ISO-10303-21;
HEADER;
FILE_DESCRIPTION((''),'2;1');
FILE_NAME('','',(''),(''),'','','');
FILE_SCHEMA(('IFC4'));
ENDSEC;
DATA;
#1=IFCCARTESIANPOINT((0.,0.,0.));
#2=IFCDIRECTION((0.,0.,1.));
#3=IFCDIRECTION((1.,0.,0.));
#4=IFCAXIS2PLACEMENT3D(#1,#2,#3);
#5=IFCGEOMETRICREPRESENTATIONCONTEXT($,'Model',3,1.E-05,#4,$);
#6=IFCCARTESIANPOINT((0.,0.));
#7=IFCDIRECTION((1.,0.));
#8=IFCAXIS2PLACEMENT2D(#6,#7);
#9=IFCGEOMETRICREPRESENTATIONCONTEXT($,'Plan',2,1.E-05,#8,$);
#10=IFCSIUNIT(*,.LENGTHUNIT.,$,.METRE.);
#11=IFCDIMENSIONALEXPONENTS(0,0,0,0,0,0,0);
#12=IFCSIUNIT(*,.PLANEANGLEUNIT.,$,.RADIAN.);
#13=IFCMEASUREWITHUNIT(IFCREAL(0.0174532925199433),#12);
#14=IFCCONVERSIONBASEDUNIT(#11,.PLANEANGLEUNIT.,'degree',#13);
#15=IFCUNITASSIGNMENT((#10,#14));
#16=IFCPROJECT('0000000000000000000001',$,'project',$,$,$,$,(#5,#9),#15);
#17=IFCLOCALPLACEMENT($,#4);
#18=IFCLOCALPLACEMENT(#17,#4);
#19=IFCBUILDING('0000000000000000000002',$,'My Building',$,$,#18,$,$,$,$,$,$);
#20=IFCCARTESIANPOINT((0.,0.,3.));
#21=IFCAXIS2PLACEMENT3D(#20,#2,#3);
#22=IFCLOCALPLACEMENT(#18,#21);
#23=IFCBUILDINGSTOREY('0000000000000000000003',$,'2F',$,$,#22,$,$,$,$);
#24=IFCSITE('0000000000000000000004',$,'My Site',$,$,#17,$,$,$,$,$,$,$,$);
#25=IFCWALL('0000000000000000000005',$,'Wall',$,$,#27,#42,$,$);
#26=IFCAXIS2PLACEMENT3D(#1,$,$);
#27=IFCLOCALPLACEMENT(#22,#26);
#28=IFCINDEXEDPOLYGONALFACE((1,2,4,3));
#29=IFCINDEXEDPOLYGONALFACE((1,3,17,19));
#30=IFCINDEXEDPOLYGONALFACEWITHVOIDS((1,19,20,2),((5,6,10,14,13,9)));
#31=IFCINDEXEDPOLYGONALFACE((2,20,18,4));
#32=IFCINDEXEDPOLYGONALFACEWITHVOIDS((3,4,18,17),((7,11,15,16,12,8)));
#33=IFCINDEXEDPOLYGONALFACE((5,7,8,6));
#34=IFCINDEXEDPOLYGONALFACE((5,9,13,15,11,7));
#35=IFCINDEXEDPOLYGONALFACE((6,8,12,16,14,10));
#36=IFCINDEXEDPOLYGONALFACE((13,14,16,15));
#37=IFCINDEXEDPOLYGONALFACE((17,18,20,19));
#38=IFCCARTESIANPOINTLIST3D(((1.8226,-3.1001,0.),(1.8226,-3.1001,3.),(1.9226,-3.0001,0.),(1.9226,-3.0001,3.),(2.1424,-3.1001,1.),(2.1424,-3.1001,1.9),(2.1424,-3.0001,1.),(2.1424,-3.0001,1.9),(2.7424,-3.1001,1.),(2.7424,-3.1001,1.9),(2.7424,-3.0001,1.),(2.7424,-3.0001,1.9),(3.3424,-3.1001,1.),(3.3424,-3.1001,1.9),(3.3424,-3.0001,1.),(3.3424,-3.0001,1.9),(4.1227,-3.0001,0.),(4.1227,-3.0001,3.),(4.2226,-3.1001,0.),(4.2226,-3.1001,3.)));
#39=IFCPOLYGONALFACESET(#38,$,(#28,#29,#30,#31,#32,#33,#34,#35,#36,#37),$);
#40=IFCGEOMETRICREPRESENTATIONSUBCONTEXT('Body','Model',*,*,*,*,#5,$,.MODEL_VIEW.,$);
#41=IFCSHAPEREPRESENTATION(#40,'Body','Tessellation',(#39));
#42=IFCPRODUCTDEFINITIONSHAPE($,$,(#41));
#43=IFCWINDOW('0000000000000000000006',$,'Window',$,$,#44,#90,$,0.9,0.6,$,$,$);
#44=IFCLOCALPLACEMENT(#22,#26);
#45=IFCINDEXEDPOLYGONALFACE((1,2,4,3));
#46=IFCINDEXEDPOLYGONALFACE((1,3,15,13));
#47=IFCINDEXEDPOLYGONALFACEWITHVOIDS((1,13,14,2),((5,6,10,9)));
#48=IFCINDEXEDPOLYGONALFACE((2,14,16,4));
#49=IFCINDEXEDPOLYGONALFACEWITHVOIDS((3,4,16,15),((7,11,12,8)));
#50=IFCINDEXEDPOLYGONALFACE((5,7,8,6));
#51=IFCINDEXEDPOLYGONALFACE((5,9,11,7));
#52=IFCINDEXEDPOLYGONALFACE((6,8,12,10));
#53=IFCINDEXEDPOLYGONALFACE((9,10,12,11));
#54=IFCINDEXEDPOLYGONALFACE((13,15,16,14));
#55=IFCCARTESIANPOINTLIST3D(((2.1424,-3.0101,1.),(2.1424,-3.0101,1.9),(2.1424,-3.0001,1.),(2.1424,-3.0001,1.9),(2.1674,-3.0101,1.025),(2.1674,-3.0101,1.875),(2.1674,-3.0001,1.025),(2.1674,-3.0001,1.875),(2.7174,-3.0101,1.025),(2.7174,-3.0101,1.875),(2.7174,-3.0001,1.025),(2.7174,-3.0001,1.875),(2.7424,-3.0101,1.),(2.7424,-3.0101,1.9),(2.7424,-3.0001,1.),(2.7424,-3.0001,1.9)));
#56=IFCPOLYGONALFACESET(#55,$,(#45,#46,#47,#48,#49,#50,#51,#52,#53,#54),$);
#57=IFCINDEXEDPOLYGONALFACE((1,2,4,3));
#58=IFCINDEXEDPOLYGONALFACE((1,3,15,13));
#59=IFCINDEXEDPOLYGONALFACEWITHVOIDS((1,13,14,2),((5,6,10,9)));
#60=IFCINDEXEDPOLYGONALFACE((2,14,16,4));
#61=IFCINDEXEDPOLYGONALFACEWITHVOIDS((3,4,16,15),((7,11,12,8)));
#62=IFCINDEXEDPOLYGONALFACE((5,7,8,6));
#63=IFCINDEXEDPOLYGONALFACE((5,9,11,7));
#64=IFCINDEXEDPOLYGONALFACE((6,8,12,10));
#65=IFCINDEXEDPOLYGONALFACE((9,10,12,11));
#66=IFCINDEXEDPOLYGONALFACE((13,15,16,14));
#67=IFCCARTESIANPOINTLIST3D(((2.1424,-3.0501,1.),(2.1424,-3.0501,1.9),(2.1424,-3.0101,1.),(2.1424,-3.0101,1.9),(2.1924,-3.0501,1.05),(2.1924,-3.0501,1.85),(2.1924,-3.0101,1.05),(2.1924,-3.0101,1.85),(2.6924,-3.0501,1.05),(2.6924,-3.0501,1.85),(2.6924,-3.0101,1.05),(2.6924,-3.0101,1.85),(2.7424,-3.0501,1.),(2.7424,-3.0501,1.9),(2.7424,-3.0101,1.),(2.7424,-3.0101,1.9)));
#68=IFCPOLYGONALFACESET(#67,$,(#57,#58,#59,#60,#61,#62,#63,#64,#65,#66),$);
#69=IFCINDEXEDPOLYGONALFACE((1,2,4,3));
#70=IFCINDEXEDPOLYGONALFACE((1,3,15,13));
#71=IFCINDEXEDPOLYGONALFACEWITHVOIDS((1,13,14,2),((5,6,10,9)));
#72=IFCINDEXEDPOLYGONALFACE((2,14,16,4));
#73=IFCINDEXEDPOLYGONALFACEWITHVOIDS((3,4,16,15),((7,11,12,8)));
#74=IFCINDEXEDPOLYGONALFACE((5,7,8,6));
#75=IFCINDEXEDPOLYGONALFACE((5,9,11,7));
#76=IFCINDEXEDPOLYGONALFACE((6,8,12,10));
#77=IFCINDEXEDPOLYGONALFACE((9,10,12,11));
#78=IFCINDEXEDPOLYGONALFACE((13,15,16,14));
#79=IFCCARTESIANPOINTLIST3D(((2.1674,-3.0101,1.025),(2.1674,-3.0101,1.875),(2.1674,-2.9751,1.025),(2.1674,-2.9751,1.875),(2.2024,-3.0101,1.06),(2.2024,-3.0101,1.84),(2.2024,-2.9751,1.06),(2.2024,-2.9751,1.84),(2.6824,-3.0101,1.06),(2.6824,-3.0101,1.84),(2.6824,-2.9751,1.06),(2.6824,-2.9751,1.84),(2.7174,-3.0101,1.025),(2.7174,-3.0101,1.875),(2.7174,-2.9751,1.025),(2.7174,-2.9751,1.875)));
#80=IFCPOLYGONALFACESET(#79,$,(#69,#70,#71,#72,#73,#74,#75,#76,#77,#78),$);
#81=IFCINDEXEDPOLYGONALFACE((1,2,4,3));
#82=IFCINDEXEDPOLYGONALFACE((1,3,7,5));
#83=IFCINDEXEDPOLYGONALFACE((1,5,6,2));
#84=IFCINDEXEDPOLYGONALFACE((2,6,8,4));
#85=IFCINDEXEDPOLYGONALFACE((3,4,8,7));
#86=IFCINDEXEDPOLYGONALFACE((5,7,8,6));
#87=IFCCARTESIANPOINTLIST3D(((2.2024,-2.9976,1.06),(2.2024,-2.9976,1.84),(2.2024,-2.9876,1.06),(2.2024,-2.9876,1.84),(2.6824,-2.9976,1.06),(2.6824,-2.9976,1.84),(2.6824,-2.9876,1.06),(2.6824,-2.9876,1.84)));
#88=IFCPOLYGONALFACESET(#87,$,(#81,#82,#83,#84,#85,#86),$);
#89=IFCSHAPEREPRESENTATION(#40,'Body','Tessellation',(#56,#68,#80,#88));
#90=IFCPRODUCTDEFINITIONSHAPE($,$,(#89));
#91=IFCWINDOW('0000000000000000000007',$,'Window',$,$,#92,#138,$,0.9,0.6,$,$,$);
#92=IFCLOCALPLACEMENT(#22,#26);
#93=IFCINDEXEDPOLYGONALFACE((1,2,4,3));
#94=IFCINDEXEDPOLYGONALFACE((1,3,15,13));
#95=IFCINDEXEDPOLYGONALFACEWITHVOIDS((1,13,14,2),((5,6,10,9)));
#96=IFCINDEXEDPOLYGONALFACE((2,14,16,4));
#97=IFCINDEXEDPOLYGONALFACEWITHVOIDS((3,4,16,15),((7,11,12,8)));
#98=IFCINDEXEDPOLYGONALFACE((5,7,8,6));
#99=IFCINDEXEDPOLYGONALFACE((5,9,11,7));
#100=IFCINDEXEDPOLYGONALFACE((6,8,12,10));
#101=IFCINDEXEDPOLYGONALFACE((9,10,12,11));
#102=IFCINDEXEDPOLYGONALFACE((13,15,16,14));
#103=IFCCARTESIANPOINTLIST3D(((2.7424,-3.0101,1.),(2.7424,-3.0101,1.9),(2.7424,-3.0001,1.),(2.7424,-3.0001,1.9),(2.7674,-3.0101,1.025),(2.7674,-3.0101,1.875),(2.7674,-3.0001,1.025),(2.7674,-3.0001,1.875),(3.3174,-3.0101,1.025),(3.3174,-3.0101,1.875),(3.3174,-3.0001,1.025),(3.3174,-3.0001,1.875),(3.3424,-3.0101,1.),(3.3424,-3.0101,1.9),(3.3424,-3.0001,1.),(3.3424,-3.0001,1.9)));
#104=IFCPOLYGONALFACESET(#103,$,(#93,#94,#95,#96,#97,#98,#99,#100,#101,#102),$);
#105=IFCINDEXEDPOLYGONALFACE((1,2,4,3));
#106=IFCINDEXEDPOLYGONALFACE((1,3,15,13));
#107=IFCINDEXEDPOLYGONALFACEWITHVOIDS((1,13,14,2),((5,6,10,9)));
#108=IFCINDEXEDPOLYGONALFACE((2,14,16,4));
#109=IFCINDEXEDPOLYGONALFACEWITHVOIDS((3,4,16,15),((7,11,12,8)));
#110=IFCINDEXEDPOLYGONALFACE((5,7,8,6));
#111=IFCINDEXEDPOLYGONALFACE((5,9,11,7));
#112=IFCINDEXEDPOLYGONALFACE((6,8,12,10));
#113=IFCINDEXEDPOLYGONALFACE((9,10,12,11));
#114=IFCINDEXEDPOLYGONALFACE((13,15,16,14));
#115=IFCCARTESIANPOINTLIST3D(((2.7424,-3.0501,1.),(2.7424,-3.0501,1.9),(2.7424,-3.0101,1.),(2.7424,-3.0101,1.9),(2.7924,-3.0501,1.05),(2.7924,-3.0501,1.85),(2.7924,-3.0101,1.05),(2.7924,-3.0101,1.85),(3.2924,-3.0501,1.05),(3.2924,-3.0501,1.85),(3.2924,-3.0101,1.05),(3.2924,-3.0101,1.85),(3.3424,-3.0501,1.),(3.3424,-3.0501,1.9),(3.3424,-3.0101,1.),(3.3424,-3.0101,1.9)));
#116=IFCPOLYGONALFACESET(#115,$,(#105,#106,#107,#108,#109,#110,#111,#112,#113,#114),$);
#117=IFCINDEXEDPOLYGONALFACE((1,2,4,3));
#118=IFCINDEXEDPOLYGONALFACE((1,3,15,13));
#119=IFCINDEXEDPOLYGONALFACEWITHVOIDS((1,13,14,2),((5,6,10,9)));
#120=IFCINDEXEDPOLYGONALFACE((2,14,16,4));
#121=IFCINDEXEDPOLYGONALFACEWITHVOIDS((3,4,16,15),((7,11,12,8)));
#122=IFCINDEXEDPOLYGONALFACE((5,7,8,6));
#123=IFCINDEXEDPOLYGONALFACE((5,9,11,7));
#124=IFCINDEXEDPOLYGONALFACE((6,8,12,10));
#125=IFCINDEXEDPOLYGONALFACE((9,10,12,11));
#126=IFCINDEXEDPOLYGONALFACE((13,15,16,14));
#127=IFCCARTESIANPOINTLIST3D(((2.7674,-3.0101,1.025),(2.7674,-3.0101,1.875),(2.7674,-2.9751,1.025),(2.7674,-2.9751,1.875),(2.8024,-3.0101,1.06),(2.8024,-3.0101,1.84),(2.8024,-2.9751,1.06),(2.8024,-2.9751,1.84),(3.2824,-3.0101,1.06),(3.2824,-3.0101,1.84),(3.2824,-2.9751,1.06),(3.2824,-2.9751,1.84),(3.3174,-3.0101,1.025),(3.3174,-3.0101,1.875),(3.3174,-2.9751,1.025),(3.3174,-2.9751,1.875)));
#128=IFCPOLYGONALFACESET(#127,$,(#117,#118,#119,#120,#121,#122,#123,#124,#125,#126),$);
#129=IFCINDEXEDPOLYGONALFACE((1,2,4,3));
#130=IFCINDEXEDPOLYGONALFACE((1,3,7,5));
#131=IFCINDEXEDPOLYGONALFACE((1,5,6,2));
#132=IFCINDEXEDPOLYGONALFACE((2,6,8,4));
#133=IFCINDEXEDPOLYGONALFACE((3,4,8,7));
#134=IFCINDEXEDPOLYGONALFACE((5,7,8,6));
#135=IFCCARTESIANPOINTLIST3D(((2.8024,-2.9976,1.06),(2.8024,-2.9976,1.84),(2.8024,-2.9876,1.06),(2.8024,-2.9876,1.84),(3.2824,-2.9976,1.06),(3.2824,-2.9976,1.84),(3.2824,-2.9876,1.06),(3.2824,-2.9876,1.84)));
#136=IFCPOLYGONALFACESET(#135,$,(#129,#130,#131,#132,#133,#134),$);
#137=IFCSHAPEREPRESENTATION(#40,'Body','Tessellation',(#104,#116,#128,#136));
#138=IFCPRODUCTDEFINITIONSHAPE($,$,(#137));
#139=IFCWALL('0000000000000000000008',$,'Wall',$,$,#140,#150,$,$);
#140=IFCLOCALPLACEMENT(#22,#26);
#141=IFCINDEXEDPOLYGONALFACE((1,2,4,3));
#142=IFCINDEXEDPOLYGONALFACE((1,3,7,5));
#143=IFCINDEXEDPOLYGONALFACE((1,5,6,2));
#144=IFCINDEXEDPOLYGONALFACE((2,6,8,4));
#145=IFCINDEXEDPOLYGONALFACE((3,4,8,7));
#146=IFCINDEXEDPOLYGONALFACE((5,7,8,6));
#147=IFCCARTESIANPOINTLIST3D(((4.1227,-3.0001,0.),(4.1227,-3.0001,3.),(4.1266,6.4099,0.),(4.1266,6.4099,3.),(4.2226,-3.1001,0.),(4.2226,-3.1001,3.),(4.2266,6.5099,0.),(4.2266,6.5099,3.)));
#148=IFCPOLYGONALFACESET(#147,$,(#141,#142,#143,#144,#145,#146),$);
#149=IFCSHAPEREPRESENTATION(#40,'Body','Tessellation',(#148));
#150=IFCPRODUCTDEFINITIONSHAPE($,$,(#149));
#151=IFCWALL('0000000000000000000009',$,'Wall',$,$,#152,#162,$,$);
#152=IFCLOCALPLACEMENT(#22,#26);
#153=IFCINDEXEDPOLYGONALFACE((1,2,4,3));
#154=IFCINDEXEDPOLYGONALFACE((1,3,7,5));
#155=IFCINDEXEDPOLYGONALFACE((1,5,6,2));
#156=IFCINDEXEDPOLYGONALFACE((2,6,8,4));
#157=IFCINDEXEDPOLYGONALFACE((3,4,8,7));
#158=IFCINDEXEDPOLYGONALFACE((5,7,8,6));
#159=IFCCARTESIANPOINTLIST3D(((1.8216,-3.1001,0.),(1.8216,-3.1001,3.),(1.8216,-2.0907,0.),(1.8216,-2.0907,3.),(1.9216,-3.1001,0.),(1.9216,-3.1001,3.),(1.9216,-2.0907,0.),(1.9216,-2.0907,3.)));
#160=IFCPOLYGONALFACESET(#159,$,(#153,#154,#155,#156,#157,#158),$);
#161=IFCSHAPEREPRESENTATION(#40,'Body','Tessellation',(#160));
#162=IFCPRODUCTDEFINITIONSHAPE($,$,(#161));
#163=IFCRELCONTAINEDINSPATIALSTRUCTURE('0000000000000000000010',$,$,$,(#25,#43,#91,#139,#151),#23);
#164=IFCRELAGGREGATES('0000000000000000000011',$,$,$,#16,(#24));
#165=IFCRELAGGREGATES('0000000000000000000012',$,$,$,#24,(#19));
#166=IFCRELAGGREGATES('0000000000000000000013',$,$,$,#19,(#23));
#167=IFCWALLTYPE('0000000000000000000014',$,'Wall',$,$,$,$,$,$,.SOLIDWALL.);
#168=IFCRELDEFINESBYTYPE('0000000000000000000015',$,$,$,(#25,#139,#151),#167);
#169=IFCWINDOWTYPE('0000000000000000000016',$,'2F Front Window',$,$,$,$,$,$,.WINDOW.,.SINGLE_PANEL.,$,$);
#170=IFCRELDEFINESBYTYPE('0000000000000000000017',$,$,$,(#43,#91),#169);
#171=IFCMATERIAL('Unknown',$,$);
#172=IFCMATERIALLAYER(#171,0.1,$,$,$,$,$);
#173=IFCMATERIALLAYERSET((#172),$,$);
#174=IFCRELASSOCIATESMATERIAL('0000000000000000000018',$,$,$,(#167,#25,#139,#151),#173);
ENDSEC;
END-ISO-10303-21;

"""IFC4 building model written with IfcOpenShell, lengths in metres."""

from ifc_helpers import new_model, entity, si_unit, converted_unit, frame, origin_with_axes, origin_2d_with_axis, place, context, subcontext, project, spatial, line, indexed_curve, outline, extrude, shape, source, transform, mapped, material, layer, layer_set, layer_usage, type_object, type_shapes, element, fill, save


model = new_model("IFC4")

# Units and contexts
model_context = context("Model", 3, precision=1e-05, world=origin_with_axes())
plan_context = context("Plan", 2, precision=1e-05, world=origin_2d_with_axis())
body_context_1 = subcontext(model_context, "Body", "Model", "MODEL_VIEW")
body_context_2 = subcontext(plan_context, "Body", "Plan", "PLAN_VIEW")
ifc_project = project(units=[si_unit("LENGTHUNIT", "METRE"), converted_unit("PLANEANGLEUNIT", "degree", entity("IfcReal", 0.0174532925199433), si_unit("PLANEANGLEUNIT", "RADIAN"), dimensions=[0, 0, 0, 0, 0, 0, 0])], contexts=[model_context, plan_context])

# Site, building, storey
site_placement = place(None, origin_with_axes())
site = spatial("IfcSite", under=ifc_project, at=site_placement, Name="My Site")
building_placement = place(site_placement, origin_with_axes())
building = spatial("IfcBuilding", under=site, at=building_placement, Name="My Building")
storey_placement = place(building_placement, frame((0.0, 0.0, 3.0), z_axis=(0.0, 0.0, 1.0), x_axis=(1.0, 0.0, 0.0)))
storey = spatial("IfcBuildingStorey", under=building, at=storey_placement, Name="2F")

# Shared definitions
ifc_material = material(Name="Unknown")

# Wall, openings, windows
ifc_layer = layer(ifc_material, 0.1)
ifc_layer_set = layer_set([ifc_layer])
ifc_layer_usage_1 = layer_usage(ifc_layer_set, "AXIS2", "POSITIVE", 0.0)
wall_type = type_object("IfcWallType", Name="Wall", PredefinedType="SOLIDWALL", material=ifc_layer_set)
wall_1_placement = place(storey_placement, frame((1.8226, -3.1001, 0.0), z_axis=(0.0, 0.0, 1.0), x_axis=(1.0, 0.0, 0.0)))
wall_1 = element("IfcWall", 1, at=wall_1_placement, inside=storey, type_object=wall_type, material=ifc_layer_usage_1, Name="Wall", context=body_context_1, shape_type="SweptSolid", body=[
    extrude(outline(indexed_curve([(0.0, 0.0), (0.1, 0.1), (2.3, 0.1), (2.4, 0.0)], segments=[line(1, 2, 3, 4, 1)])), origin_with_axes(), (0.0, 0.0, 1.0), 3.0),
])
shared_shape_1 = source(origin_with_axes(), body_context_1, "Body", "SweptSolid", [
    extrude(outline(indexed_curve([(0.0, 0.0), (0.6, 0.0), (0.6, 0.9), (0.0, 0.9)], segments=[line(1, 2, 3, 4, 1)])), frame((0.0, -0.6, 0.0), z_axis=(0.0, -1.0, 0.0), x_axis=(1.0, 0.0, 0.0)), (0.0, 0.0, -1.0), 1.2),
])
opening_1_placement = place(wall_1_placement, frame((0.3197, 0.0, 1.0), z_axis=(0.0, 0.0, 1.0), x_axis=(1.0, 0.0, 0.0)))
opening_1 = element("IfcOpeningElement", 2, at=opening_1_placement, cuts=wall_1, PredefinedType="OPENING", context=body_context_1, shape_type="MappedRepresentation", body=[
    mapped(shared_shape_1, transform((0.0, 0.0, 0.0), x_axis=(1.0, 0.0, 0.0), y_axis=(0.0, 1.0, 0.0), z_axis=(0.0, 0.0, 1.0), scale=1.0)),
])
opening_2_placement = place(wall_1_placement, frame((0.9197, 0.0, 1.0), z_axis=(0.0, 0.0, 1.0), x_axis=(1.0, 0.0, 0.0)))
opening_2 = element("IfcOpeningElement", 3, at=opening_2_placement, cuts=wall_1, PredefinedType="OPENING", context=body_context_1, shape_type="MappedRepresentation", body=[
    mapped(shared_shape_1, transform((0.0, 0.0, 0.0), x_axis=(1.0, 0.0, 0.0), y_axis=(0.0, 1.0, 0.0), z_axis=(0.0, 0.0, 1.0), scale=1.0)),
])
window_type_1 = type_object("IfcWindowType", Name="2F Front Window", PartitioningType="SINGLE_PANEL", PredefinedType="WINDOW")
shared_shape_2 = source(origin_with_axes(), body_context_1, "Body", "SweptSolid", [
    extrude(outline(indexed_curve([(0.0, 0.0), (0.6, 0.0), (0.6, 0.9), (0.0, 0.9)], segments=[line(1, 2, 3, 4, 1)]), holes=[indexed_curve([(0.025, 0.025), (0.575, 0.025), (0.575, 0.875), (0.025, 0.875)], segments=[line(1, 2, 3, 4, 1)])]), frame((0.0, 0.09, 0.0), z_axis=(0.0, -1.0, 0.0), x_axis=(1.0, 0.0, 0.0)), (0.0, 0.0, -1.0), 0.01),
    extrude(outline(indexed_curve([(0.0, 0.0), (0.6, 0.0), (0.6, 0.9), (0.0, 0.9)], segments=[line(1, 2, 3, 4, 1)]), holes=[indexed_curve([(0.05, 0.05), (0.55, 0.05), (0.55, 0.85), (0.05, 0.85)], segments=[line(1, 2, 3, 4, 1)])]), frame((0.0, 0.05, 0.0), z_axis=(0.0, -1.0, 0.0), x_axis=(1.0, 0.0, 0.0)), (0.0, 0.0, -1.0), 0.04),
    extrude(outline(indexed_curve([(0.0, 0.0), (0.55, 0.0), (0.55, 0.85), (0.0, 0.85)], segments=[line(1, 2, 3, 4, 1)]), holes=[indexed_curve([(0.035, 0.035), (0.515, 0.035), (0.515, 0.815), (0.035, 0.815)], segments=[line(1, 2, 3, 4, 1)])]), frame((0.025, 0.09, 0.025), z_axis=(0.0, -1.0, 0.0), x_axis=(1.0, 0.0, 0.0)), (0.0, 0.0, -1.0), 0.035),
    extrude(outline(indexed_curve([(0.035, 0.035), (0.515, 0.035), (0.515, 0.815), (0.035, 0.815)], segments=[line(1, 2, 3, 4, 1)])), frame((0.025, 0.1025, 0.025), z_axis=(0.0, -1.0, 0.0), x_axis=(1.0, 0.0, 0.0)), (0.0, 0.0, -1.0), 0.01),
])
shared_shape_3 = source(origin_with_axes(), body_context_2, "Body", "Curve2D", [
    entity("IfcIndexedPolyCurve", entity("IfcCartesianPointList2D", [[0.05, 0.05], [0.55, 0.05]])),
    entity("IfcIndexedPolyCurve", entity("IfcCartesianPointList2D", [[0.0, 0.1], [0.025, 0.1], [0.025, 0.09], [0.05, 0.09], [0.05, 0.05], [0.0, 0.05]]), [entity("IfcLineIndex", [1, 2, 3, 4, 5, 6, 1])]),
    entity("IfcIndexedPolyCurve", entity("IfcCartesianPointList2D", [[0.6, 0.1], [0.575, 0.1], [0.575, 0.09], [0.55, 0.09], [0.55, 0.05], [0.6, 0.05]]), [entity("IfcLineIndex", [1, 2, 3, 4, 5, 6, 1])]),
    entity("IfcIndexedPolyCurve", entity("IfcCartesianPointList2D", [[0.025, 0.09], [0.06, 0.09], [0.06, 0.125], [0.025, 0.125]]), [entity("IfcLineIndex", [1, 2, 3, 4, 1])]),
    entity("IfcIndexedPolyCurve", entity("IfcCartesianPointList2D", [[0.575, 0.09], [0.54, 0.09], [0.54, 0.125], [0.575, 0.125]]), [entity("IfcLineIndex", [1, 2, 3, 4, 1])]),
    entity("IfcIndexedPolyCurve", entity("IfcCartesianPointList2D", [[0.06, 0.09], [0.54, 0.09]])),
    entity("IfcIndexedPolyCurve", entity("IfcCartesianPointList2D", [[0.06, 0.125], [0.54, 0.125]])),
    entity("IfcIndexedPolyCurve", entity("IfcCartesianPointList2D", [[0.06, 0.1075], [0.54, 0.1075]])),
])
type_shapes(window_type_1, [shared_shape_2, shared_shape_3])
window_1_placement = place(opening_1_placement, origin_with_axes())
window_1 = element("IfcWindow", 4, at=window_1_placement, inside=storey, type_object=window_type_1, Name="Window", OverallHeight=0.9, OverallWidth=0.6, shapes=[
    shape(body_context_1, "Body", "MappedRepresentation", [mapped(shared_shape_2, transform((0.0, 0.0, 0.0), x_axis=(1.0, 0.0, 0.0), y_axis=(0.0, 1.0, 0.0), z_axis=(0.0, 0.0, 1.0), scale=1.0))]),
    shape(body_context_2, "Body", "MappedRepresentation", [mapped(shared_shape_3, transform((0.0, 0.0, 0.0), x_axis=(1.0, 0.0, 0.0), y_axis=(0.0, 1.0, 0.0), z_axis=(0.0, 0.0, 1.0), scale=1.0))]),
])
fill(opening_1, window_1)
window_2_placement = place(opening_2_placement, origin_with_axes())
window_2 = element("IfcWindow", 5, at=window_2_placement, inside=storey, type_object=window_type_1, Name="Window", OverallHeight=0.9, OverallWidth=0.6, shapes=[
    shape(body_context_1, "Body", "MappedRepresentation", [mapped(shared_shape_2, transform((0.0, 0.0, 0.0), x_axis=(1.0, 0.0, 0.0), y_axis=(0.0, 1.0, 0.0), z_axis=(0.0, 0.0, 1.0), scale=1.0))]),
    shape(body_context_2, "Body", "MappedRepresentation", [mapped(shared_shape_3, transform((0.0, 0.0, 0.0), x_axis=(1.0, 0.0, 0.0), y_axis=(0.0, 1.0, 0.0), z_axis=(0.0, 0.0, 1.0), scale=1.0))]),
])
fill(opening_2, window_2)

# Walls
ifc_layer_usage_2 = layer_usage(ifc_layer_set, "AXIS2", "POSITIVE", 0.0)
wall_2_placement = place(storey_placement, frame((4.2226, -3.1001, 0.0), z_axis=(0.0, 0.0, 1.0), x_axis=(0.000415, 1.0, 0.0)))
element("IfcWall", 6, at=wall_2_placement, inside=storey, type_object=wall_type, material=ifc_layer_usage_2, Name="Wall", context=body_context_1, shape_type="SweptSolid", body=[
    extrude(outline(indexed_curve([(0.0, 0.0), (0.1, 0.1), (9.51, 0.1), (9.61, 0.0)], segments=[line(1, 2, 3, 4, 1)])), origin_with_axes(), (0.0, 0.0, 1.0), 3.0),
])
ifc_layer_usage_3 = layer_usage(ifc_layer_set, "AXIS2", "POSITIVE", 0.0)
wall_3_placement = place(storey_placement, frame((1.9216, -3.1001, 0.0), z_axis=(0.0, 0.0, 1.0), x_axis=(0.000002, 1.0, 0.0)))
element("IfcWall", 7, at=wall_3_placement, inside=storey, type_object=wall_type, material=ifc_layer_usage_3, Name="Wall", context=body_context_1, shape_type="SweptSolid", body=[
    extrude(outline(indexed_curve([(0.0, 0.0), (0.0, 0.1), (1.0094, 0.1), (1.0094, 0.0)], segments=[line(1, 2, 3, 4, 1)])), origin_with_axes(), (0.0, 0.0, 1.0), 3.0),
])

save(model, "model.ifc")
